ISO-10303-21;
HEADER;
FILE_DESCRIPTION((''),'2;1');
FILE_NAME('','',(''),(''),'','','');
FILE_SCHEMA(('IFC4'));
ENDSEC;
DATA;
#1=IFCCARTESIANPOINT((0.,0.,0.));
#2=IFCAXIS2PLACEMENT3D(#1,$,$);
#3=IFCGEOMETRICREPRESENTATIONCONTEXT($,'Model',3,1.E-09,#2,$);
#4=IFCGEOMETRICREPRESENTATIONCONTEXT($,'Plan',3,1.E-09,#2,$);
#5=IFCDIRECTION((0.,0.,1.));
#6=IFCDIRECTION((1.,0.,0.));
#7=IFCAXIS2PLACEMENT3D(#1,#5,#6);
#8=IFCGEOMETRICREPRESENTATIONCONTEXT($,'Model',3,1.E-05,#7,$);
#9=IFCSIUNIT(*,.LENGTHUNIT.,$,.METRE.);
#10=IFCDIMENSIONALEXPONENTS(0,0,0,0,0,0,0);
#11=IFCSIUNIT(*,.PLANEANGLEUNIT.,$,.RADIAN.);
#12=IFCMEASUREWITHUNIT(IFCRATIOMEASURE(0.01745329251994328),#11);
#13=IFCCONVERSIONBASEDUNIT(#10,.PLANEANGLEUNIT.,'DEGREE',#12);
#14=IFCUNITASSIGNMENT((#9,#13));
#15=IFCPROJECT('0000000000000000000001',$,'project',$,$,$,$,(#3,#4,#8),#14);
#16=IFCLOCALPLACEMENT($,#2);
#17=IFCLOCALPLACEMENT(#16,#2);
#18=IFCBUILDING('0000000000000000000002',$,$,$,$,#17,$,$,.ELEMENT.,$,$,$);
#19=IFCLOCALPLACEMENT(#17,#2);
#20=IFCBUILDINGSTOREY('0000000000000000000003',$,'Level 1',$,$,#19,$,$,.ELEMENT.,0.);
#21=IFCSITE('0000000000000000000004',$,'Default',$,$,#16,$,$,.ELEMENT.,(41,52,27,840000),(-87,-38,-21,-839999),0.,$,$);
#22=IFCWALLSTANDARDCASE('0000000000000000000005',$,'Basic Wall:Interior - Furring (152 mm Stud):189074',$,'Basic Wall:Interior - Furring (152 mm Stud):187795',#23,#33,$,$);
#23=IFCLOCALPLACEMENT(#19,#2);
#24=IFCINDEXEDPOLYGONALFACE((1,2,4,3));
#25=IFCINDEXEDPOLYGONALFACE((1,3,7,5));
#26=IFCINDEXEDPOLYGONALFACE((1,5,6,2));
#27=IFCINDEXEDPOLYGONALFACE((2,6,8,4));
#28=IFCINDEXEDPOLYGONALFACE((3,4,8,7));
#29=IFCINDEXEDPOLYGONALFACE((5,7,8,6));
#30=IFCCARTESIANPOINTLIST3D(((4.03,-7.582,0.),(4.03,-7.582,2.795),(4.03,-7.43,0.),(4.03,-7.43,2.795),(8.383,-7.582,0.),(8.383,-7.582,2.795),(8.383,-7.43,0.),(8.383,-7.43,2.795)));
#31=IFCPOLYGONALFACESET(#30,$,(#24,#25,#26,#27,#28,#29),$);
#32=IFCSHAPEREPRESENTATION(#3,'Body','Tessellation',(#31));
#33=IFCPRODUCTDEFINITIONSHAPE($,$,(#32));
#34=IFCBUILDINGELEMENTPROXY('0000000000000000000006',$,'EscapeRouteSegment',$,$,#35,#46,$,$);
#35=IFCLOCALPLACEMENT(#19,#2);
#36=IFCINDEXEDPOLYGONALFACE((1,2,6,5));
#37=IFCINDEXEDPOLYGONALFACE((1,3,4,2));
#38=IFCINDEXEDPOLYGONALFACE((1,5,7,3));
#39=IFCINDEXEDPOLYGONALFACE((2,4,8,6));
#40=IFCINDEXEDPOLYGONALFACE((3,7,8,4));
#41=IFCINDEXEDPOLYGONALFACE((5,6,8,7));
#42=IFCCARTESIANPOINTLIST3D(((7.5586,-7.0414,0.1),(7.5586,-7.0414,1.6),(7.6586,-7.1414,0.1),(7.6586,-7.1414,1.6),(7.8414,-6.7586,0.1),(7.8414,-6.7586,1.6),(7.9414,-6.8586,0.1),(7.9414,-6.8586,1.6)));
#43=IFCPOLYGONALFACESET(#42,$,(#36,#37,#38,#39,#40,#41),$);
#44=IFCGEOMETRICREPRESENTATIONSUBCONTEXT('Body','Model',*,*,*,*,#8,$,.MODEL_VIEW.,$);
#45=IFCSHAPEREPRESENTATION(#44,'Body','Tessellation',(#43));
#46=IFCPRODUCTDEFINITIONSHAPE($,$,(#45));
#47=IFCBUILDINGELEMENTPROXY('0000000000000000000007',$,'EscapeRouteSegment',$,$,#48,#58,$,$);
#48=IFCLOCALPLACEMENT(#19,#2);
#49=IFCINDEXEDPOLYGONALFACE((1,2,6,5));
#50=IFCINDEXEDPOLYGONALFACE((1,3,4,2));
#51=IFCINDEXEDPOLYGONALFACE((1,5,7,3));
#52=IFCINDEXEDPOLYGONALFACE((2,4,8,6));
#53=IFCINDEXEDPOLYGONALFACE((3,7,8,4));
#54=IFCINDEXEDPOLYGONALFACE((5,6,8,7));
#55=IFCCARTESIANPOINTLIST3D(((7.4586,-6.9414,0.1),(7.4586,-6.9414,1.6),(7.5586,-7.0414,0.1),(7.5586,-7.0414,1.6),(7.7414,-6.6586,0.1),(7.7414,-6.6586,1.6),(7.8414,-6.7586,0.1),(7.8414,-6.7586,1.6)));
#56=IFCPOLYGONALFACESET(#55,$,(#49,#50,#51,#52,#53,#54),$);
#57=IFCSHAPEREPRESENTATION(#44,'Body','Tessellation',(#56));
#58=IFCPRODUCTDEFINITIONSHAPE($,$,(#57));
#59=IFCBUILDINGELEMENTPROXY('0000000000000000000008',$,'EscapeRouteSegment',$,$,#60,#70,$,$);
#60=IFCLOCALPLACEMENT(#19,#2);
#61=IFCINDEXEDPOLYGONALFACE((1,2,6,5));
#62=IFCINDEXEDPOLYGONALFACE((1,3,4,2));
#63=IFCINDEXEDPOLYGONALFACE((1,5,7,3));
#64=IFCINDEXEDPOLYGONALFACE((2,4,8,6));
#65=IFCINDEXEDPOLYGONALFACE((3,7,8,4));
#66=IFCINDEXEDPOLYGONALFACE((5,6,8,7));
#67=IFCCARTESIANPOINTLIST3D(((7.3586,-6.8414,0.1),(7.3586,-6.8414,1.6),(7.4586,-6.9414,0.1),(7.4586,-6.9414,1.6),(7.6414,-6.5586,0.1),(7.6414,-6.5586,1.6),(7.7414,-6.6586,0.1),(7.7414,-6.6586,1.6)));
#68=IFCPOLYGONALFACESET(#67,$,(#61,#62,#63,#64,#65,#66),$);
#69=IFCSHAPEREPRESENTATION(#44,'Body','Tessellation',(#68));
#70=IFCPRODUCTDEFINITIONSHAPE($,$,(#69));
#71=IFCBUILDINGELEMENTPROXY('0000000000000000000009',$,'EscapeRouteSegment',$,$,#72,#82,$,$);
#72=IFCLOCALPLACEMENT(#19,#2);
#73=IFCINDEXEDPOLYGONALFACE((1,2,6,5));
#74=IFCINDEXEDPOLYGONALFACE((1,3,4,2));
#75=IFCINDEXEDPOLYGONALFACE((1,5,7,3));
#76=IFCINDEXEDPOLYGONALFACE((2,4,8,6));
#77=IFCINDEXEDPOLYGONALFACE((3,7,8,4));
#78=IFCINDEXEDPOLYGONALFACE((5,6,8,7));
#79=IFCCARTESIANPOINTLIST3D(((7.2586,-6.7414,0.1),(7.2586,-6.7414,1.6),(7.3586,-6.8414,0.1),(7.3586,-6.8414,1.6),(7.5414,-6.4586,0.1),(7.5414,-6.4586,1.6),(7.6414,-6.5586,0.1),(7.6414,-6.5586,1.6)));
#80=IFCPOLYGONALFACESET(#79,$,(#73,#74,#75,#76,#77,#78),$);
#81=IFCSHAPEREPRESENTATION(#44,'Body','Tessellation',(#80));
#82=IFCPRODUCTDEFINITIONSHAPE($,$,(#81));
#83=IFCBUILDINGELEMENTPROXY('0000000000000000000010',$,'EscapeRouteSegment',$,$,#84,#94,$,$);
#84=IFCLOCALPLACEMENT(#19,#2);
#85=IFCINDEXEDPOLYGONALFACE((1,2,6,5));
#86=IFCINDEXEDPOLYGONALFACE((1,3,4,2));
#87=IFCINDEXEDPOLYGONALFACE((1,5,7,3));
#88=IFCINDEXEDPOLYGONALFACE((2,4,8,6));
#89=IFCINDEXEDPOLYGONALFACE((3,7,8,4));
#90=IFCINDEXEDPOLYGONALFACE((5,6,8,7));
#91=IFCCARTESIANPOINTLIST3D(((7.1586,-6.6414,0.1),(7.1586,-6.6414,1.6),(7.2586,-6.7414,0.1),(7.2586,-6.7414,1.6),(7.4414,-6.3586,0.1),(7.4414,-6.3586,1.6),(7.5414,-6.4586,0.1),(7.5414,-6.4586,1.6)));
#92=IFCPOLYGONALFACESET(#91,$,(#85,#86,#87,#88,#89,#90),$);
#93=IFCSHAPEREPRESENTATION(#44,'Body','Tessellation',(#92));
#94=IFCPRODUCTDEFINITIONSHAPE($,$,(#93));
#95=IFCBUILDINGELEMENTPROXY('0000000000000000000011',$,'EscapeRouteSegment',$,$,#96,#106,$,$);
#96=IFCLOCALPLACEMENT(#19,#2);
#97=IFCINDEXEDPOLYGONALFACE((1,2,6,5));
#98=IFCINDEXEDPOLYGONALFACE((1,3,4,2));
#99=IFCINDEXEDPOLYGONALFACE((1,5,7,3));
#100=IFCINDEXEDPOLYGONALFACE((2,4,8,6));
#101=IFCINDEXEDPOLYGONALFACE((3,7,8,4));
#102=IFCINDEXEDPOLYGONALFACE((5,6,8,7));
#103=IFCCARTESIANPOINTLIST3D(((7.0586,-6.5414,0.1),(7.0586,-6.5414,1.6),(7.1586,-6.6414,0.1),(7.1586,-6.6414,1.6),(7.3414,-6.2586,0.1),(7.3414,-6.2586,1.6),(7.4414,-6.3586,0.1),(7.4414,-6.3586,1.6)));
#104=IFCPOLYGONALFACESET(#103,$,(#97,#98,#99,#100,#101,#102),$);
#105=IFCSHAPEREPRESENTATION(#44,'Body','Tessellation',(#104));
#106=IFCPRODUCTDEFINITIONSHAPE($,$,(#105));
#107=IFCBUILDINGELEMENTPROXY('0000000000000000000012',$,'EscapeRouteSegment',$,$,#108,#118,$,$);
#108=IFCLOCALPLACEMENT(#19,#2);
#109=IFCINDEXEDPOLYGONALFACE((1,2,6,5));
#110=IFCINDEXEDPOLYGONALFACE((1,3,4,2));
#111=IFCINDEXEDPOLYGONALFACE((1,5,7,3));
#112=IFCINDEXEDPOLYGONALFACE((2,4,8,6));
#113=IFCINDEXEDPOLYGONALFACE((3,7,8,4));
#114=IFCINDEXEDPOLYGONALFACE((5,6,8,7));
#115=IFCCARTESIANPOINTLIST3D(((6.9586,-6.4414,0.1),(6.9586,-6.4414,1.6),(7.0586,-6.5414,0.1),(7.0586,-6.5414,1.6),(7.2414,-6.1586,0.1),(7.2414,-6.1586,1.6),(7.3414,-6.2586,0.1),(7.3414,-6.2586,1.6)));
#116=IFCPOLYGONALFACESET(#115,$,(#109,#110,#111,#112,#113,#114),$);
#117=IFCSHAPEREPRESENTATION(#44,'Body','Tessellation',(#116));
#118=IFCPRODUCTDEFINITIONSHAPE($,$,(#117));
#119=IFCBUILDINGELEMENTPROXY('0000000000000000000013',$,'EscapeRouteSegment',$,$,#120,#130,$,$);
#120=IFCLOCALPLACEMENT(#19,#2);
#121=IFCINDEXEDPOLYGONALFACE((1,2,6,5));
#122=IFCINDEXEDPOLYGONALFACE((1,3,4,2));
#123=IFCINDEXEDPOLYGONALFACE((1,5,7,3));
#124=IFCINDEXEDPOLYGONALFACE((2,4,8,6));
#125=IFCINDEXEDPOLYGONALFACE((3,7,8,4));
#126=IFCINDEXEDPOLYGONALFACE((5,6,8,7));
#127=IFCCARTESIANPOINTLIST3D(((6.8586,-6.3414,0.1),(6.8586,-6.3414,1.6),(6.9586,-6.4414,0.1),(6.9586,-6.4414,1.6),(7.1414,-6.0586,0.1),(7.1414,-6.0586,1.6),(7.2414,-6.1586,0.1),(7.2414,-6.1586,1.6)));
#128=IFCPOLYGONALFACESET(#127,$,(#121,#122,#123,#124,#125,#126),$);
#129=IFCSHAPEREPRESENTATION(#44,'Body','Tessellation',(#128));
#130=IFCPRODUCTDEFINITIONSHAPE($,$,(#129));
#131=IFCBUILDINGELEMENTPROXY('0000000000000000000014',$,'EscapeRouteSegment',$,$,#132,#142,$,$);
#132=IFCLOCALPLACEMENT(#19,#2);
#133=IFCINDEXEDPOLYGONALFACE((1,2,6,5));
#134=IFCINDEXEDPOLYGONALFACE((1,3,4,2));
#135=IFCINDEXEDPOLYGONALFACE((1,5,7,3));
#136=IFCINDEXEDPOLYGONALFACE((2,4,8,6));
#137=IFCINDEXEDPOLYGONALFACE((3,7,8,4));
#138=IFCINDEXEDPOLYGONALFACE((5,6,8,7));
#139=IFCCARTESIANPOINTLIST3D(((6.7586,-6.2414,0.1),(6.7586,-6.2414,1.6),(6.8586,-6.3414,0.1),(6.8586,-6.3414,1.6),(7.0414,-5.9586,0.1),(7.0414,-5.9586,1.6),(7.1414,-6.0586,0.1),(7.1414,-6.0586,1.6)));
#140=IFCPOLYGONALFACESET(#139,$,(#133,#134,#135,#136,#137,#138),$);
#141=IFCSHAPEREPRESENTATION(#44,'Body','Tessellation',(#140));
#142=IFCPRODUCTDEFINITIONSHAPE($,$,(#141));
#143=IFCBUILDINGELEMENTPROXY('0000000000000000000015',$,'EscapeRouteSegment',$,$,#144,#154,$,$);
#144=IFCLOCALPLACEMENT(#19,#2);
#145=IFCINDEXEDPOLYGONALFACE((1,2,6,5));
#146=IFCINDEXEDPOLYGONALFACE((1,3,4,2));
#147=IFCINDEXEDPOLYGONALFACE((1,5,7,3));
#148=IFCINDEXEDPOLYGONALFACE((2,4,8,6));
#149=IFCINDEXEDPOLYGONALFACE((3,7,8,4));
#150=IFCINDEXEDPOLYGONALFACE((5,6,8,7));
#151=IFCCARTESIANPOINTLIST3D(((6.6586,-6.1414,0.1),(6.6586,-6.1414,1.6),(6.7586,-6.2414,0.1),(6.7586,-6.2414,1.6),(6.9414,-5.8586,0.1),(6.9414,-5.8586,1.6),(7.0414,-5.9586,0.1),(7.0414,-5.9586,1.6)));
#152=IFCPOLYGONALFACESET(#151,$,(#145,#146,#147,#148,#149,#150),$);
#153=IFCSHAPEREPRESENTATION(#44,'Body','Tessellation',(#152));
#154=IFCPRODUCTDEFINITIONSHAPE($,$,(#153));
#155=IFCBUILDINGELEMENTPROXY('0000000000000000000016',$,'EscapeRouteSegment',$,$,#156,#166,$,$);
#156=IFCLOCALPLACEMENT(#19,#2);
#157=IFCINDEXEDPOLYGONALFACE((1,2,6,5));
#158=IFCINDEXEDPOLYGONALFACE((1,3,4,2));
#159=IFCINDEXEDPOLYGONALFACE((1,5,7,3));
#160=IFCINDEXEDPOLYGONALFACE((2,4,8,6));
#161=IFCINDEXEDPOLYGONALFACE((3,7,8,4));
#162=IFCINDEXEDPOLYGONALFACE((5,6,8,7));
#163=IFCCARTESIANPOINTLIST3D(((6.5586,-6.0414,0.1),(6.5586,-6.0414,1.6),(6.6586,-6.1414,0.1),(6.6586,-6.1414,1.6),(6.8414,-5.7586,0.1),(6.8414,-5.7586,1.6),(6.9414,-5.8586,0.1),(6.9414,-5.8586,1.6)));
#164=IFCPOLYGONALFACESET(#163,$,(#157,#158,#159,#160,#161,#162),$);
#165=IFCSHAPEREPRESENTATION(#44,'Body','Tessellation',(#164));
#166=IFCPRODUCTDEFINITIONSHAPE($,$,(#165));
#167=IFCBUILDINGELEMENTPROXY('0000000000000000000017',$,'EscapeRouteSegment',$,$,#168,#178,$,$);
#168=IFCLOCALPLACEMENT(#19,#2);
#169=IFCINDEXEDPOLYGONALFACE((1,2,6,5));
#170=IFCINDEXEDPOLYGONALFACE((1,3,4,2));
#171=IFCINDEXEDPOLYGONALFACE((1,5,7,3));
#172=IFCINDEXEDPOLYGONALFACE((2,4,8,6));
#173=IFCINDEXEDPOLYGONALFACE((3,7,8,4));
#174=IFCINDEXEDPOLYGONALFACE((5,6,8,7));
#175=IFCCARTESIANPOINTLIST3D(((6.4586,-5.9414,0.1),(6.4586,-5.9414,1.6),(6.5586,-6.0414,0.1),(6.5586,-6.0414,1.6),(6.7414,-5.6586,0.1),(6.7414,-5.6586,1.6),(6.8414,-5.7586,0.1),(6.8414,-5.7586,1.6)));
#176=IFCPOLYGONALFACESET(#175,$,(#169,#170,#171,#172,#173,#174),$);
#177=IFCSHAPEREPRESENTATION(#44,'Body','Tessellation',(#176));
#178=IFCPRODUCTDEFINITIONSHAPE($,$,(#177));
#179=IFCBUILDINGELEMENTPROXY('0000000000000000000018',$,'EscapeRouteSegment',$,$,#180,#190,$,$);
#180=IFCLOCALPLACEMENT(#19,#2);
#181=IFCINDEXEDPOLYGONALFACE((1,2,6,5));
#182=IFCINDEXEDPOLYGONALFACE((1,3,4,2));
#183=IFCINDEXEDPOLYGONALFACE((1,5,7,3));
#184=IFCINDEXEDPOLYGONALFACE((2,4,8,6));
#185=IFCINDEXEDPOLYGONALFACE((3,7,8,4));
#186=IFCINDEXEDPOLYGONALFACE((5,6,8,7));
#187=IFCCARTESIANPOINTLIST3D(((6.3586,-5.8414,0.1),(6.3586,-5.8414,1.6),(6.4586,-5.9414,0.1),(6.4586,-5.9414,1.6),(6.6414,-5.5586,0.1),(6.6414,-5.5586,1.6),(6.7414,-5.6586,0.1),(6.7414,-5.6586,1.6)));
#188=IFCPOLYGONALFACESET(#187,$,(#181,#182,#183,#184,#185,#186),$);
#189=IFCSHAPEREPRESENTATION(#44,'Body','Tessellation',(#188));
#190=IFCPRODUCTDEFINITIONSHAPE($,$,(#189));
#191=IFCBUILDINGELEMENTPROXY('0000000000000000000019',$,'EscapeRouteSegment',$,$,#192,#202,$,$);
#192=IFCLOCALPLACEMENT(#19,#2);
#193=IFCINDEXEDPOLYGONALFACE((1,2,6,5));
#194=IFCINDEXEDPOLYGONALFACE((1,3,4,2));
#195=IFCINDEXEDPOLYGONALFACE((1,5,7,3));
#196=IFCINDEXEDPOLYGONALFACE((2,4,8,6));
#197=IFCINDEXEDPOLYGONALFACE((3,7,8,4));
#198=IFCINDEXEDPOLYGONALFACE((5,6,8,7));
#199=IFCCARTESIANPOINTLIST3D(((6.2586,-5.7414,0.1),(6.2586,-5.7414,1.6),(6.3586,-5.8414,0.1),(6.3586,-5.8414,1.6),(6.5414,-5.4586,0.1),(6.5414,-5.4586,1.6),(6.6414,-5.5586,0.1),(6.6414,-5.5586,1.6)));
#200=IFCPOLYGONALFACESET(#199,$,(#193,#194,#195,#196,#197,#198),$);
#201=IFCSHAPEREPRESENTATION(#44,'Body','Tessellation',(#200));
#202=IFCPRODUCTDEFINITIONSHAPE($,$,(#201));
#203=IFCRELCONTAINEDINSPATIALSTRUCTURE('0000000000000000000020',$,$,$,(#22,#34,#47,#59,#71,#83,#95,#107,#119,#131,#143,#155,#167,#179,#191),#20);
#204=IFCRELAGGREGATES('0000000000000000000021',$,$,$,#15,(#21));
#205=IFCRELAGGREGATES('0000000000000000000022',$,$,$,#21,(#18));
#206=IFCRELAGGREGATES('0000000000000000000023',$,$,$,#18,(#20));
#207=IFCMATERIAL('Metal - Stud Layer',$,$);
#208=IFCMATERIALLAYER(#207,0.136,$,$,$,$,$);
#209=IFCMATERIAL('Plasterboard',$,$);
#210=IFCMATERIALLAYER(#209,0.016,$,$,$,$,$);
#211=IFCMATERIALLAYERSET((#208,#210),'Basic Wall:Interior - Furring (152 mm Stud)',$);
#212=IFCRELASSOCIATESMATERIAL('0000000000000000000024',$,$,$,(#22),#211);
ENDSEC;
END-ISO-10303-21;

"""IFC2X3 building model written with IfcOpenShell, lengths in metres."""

from ifc_helpers import new_model, entity, si_unit, converted_unit, frame, frame_2d, origin, origin_with_axes, place, context, subcontext, project, spatial, polyline, rectangle, outline, extrude, clip, bounded_halfspace, material, layer, layer_set, layer_usage, element, save


model = new_model("IFC2X3")

# Units and contexts
model_context_1 = context("Model", 3, precision=1e-09, world=origin())
plan_context = context("Plan", 3, precision=1e-09, world=origin())
model_context_2 = context("Model", 3, precision=1e-05, world=origin_with_axes())
body_context = subcontext(model_context_2, "Body", "Model", "MODEL_VIEW")
ifc_project = project(units=[si_unit("LENGTHUNIT", "METRE"), converted_unit("PLANEANGLEUNIT", "DEGREE", entity("IfcRatioMeasure", 0.01745329251994328), si_unit("PLANEANGLEUNIT", "RADIAN"), dimensions=[0, 0, 0, 0, 0, 0, 0])], contexts=[model_context_1, plan_context, model_context_2])

# Site, building, storey
site_placement = place(None, origin())
site = spatial("IfcSite", under=ifc_project, at=site_placement, Name="Default", CompositionType="ELEMENT", RefLatitude=(41, 52, 27, 840000), RefLongitude=(-87, -38, -21, -839999), RefElevation=0.0)
building_placement = place(site_placement, origin())
building = spatial("IfcBuilding", under=site, at=building_placement, CompositionType="ELEMENT")
storey_placement = place(building_placement, origin())
storey = spatial("IfcBuildingStorey", under=building, at=storey_placement, Name="Level 1", CompositionType="ELEMENT", Elevation=0.0)

# Wall
ifc_material_1 = material(Name="Plasterboard")
ifc_material_2 = material(Name="Metal - Stud Layer")
ifc_layer_1 = layer(ifc_material_2, 0.136)
ifc_layer_2 = layer(ifc_material_1, 0.016)
ifc_layer_set_1 = layer_set([ifc_layer_1, ifc_layer_2], Name="Basic Wall:Interior - Furring (152 mm Stud)")
ifc_layer_usage_1 = layer_usage(ifc_layer_set_1, "AXIS2", "NEGATIVE", 0.076)
wall_1_placement = place(storey_placement, frame((8.383, -7.506, 0.0), z_axis=(0.0, 0.0, 1.0), x_axis=(-1.0, 0.0, 0.0)))
element("IfcWallStandardCase", 1, at=wall_1_placement, inside=storey, material=ifc_layer_usage_1, Name="Basic Wall:Interior - Furring (152 mm Stud):189074", ObjectType="Basic Wall:Interior - Furring (152 mm Stud):187795", context=model_context_1, shape_type="Clipping", body=[
    clip(extrude(rectangle(XDim=4.353, YDim=0.152, at=frame_2d((2.1765, 0.0), x_axis=(-1.0, 0.0))), origin(), (0.0, 0.0, 1.0), 2.795), bounded_halfspace(frame((0.0, -0.076, 2.795), z_axis=(0.0, 0.0, -1.0), x_axis=(0.0, 1.0, 0.0)), True, frame((0.0, -0.076, 2.795)), polyline([(0.0, 0.0), (3.708, 0.0), (3.708, 0.152), (0.0, 0.152), (0.0, 0.0)]))),
])

# Building element proxies
proxy_1_placement = place(storey_placement, frame((7.8, -7.0, 0.1), z_axis=(0.0, 0.0, 1.0), x_axis=(-0.707108, 0.707105, 0.0)))
element("IfcBuildingElementProxy", 2, at=proxy_1_placement, inside=storey, Name="EscapeRouteSegment", context=body_context, shape_type="SweptSolid", body=[
    extrude(outline(polyline([(0.0, -0.2), (0.0, 0.2), (0.1414, 0.2), (0.1414, -0.2), (0.0, -0.2)])), origin_with_axes(), (0.0, 0.0, 1.0), 1.5),
])
proxy_2_placement = place(storey_placement, frame((7.7, -6.9, 0.1), z_axis=(0.0, 0.0, 1.0), x_axis=(-0.707107, 0.707107, 0.0)))
element("IfcBuildingElementProxy", 3, at=proxy_2_placement, inside=storey, Name="EscapeRouteSegment", context=body_context, shape_type="SweptSolid", body=[
    extrude(outline(polyline([(0.0, -0.2), (0.0, 0.2), (0.1414, 0.2), (0.1414, -0.2), (0.0, -0.2)])), origin_with_axes(), (0.0, 0.0, 1.0), 1.5),
])
proxy_3_placement = place(storey_placement, frame((7.6, -6.8, 0.1), z_axis=(0.0, 0.0, 1.0), x_axis=(-0.707105, 0.707108, 0.0)))
element("IfcBuildingElementProxy", 4, at=proxy_3_placement, inside=storey, Name="EscapeRouteSegment", context=body_context, shape_type="SweptSolid", body=[
    extrude(outline(polyline([(0.0, -0.2), (0.0, 0.2), (0.1414, 0.2), (0.1414, -0.2), (0.0, -0.2)])), origin_with_axes(), (0.0, 0.0, 1.0), 1.5),
])
for number, where, z_axis, x_axis, name in (
    (5, (7.5, -6.7, 0.1), (0.0, 0.0, 1.0), (-0.707107, 0.707107, 0.0), "EscapeRouteSegment"),
    (6, (7.4, -6.6, 0.1), (0.0, 0.0, 1.0), (-0.707107, 0.707107, 0.0), "EscapeRouteSegment"),
):
    element("IfcBuildingElementProxy", number, at=place(storey_placement, frame(where, z_axis=z_axis, x_axis=x_axis)), inside=storey, Name=name, context=body_context, shape_type="SweptSolid", body=[
        extrude(outline(polyline([(0.0, -0.2), (0.0, 0.2), (0.1414, 0.2), (0.1414, -0.2), (0.0, -0.2)])), origin_with_axes(), (0.0, 0.0, 1.0), 1.5),
    ])
proxy_4_placement = place(storey_placement, frame((7.3, -6.5, 0.1), z_axis=(0.0, 0.0, 1.0), x_axis=(-0.707108, 0.707105, 0.0)))
element("IfcBuildingElementProxy", 7, at=proxy_4_placement, inside=storey, Name="EscapeRouteSegment", context=body_context, shape_type="SweptSolid", body=[
    extrude(outline(polyline([(0.0, -0.2), (0.0, 0.2), (0.1414, 0.2), (0.1414, -0.2), (0.0, -0.2)])), origin_with_axes(), (0.0, 0.0, 1.0), 1.5),
])
proxy_5_placement = place(storey_placement, frame((7.2, -6.4, 0.1), z_axis=(0.0, 0.0, 1.0), x_axis=(-0.707107, 0.707107, 0.0)))
element("IfcBuildingElementProxy", 8, at=proxy_5_placement, inside=storey, Name="EscapeRouteSegment", context=body_context, shape_type="SweptSolid", body=[
    extrude(outline(polyline([(0.0, -0.2), (0.0, 0.2), (0.1414, 0.2), (0.1414, -0.2), (0.0, -0.2)])), origin_with_axes(), (0.0, 0.0, 1.0), 1.5),
])
proxy_6_placement = place(storey_placement, frame((7.1, -6.3, 0.1), z_axis=(0.0, 0.0, 1.0), x_axis=(-0.707105, 0.707108, 0.0)))
element("IfcBuildingElementProxy", 9, at=proxy_6_placement, inside=storey, Name="EscapeRouteSegment", context=body_context, shape_type="SweptSolid", body=[
    extrude(outline(polyline([(0.0, -0.2), (0.0, 0.2), (0.1414, 0.2), (0.1414, -0.2), (0.0, -0.2)])), origin_with_axes(), (0.0, 0.0, 1.0), 1.5),
])
for number, where, z_axis, x_axis, name in (
    (10, (7.0, -6.2, 0.1), (0.0, 0.0, 1.0), (-0.707107, 0.707107, 0.0), "EscapeRouteSegment"),
    (11, (6.9, -6.1, 0.1), (0.0, 0.0, 1.0), (-0.707107, 0.707107, 0.0), "EscapeRouteSegment"),
):
    element("IfcBuildingElementProxy", number, at=place(storey_placement, frame(where, z_axis=z_axis, x_axis=x_axis)), inside=storey, Name=name, context=body_context, shape_type="SweptSolid", body=[
        extrude(outline(polyline([(0.0, -0.2), (0.0, 0.2), (0.1414, 0.2), (0.1414, -0.2), (0.0, -0.2)])), origin_with_axes(), (0.0, 0.0, 1.0), 1.5),
    ])
proxy_7_placement = place(storey_placement, frame((6.8, -6.0, 0.1), z_axis=(0.0, 0.0, 1.0), x_axis=(-0.707108, 0.707105, 0.0)))
element("IfcBuildingElementProxy", 12, at=proxy_7_placement, inside=storey, Name="EscapeRouteSegment", context=body_context, shape_type="SweptSolid", body=[
    extrude(outline(polyline([(0.0, -0.2), (0.0, 0.2), (0.1414, 0.2), (0.1414, -0.2), (0.0, -0.2)])), origin_with_axes(), (0.0, 0.0, 1.0), 1.5),
])
proxy_8_placement = place(storey_placement, frame((6.7, -5.9, 0.1), z_axis=(0.0, 0.0, 1.0), x_axis=(-0.707107, 0.707107, 0.0)))
element("IfcBuildingElementProxy", 13, at=proxy_8_placement, inside=storey, Name="EscapeRouteSegment", context=body_context, shape_type="SweptSolid", body=[
    extrude(outline(polyline([(0.0, -0.2), (0.0, 0.2), (0.1414, 0.2), (0.1414, -0.2), (0.0, -0.2)])), origin_with_axes(), (0.0, 0.0, 1.0), 1.5),
])
proxy_9_placement = place(storey_placement, frame((6.6, -5.8, 0.1), z_axis=(0.0, 0.0, 1.0), x_axis=(-0.707105, 0.707108, 0.0)))
element("IfcBuildingElementProxy", 14, at=proxy_9_placement, inside=storey, Name="EscapeRouteSegment", context=body_context, shape_type="SweptSolid", body=[
    extrude(outline(polyline([(0.0, -0.2), (0.0, 0.2), (0.1414, 0.2), (0.1414, -0.2), (0.0, -0.2)])), origin_with_axes(), (0.0, 0.0, 1.0), 1.5),
])
for number, where, z_axis, x_axis, name in (
    (15, (6.5, -5.7, 0.1), (0.0, 0.0, 1.0), (-0.707107, 0.707107, 0.0), "EscapeRouteSegment"),
):
    element("IfcBuildingElementProxy", number, at=place(storey_placement, frame(where, z_axis=z_axis, x_axis=x_axis)), inside=storey, Name=name, context=body_context, shape_type="SweptSolid", body=[
        extrude(outline(polyline([(0.0, -0.2), (0.0, 0.2), (0.1414, 0.2), (0.1414, -0.2), (0.0, -0.2)])), origin_with_axes(), (0.0, 0.0, 1.0), 1.5),
    ])

save(model, "model.ifc")
